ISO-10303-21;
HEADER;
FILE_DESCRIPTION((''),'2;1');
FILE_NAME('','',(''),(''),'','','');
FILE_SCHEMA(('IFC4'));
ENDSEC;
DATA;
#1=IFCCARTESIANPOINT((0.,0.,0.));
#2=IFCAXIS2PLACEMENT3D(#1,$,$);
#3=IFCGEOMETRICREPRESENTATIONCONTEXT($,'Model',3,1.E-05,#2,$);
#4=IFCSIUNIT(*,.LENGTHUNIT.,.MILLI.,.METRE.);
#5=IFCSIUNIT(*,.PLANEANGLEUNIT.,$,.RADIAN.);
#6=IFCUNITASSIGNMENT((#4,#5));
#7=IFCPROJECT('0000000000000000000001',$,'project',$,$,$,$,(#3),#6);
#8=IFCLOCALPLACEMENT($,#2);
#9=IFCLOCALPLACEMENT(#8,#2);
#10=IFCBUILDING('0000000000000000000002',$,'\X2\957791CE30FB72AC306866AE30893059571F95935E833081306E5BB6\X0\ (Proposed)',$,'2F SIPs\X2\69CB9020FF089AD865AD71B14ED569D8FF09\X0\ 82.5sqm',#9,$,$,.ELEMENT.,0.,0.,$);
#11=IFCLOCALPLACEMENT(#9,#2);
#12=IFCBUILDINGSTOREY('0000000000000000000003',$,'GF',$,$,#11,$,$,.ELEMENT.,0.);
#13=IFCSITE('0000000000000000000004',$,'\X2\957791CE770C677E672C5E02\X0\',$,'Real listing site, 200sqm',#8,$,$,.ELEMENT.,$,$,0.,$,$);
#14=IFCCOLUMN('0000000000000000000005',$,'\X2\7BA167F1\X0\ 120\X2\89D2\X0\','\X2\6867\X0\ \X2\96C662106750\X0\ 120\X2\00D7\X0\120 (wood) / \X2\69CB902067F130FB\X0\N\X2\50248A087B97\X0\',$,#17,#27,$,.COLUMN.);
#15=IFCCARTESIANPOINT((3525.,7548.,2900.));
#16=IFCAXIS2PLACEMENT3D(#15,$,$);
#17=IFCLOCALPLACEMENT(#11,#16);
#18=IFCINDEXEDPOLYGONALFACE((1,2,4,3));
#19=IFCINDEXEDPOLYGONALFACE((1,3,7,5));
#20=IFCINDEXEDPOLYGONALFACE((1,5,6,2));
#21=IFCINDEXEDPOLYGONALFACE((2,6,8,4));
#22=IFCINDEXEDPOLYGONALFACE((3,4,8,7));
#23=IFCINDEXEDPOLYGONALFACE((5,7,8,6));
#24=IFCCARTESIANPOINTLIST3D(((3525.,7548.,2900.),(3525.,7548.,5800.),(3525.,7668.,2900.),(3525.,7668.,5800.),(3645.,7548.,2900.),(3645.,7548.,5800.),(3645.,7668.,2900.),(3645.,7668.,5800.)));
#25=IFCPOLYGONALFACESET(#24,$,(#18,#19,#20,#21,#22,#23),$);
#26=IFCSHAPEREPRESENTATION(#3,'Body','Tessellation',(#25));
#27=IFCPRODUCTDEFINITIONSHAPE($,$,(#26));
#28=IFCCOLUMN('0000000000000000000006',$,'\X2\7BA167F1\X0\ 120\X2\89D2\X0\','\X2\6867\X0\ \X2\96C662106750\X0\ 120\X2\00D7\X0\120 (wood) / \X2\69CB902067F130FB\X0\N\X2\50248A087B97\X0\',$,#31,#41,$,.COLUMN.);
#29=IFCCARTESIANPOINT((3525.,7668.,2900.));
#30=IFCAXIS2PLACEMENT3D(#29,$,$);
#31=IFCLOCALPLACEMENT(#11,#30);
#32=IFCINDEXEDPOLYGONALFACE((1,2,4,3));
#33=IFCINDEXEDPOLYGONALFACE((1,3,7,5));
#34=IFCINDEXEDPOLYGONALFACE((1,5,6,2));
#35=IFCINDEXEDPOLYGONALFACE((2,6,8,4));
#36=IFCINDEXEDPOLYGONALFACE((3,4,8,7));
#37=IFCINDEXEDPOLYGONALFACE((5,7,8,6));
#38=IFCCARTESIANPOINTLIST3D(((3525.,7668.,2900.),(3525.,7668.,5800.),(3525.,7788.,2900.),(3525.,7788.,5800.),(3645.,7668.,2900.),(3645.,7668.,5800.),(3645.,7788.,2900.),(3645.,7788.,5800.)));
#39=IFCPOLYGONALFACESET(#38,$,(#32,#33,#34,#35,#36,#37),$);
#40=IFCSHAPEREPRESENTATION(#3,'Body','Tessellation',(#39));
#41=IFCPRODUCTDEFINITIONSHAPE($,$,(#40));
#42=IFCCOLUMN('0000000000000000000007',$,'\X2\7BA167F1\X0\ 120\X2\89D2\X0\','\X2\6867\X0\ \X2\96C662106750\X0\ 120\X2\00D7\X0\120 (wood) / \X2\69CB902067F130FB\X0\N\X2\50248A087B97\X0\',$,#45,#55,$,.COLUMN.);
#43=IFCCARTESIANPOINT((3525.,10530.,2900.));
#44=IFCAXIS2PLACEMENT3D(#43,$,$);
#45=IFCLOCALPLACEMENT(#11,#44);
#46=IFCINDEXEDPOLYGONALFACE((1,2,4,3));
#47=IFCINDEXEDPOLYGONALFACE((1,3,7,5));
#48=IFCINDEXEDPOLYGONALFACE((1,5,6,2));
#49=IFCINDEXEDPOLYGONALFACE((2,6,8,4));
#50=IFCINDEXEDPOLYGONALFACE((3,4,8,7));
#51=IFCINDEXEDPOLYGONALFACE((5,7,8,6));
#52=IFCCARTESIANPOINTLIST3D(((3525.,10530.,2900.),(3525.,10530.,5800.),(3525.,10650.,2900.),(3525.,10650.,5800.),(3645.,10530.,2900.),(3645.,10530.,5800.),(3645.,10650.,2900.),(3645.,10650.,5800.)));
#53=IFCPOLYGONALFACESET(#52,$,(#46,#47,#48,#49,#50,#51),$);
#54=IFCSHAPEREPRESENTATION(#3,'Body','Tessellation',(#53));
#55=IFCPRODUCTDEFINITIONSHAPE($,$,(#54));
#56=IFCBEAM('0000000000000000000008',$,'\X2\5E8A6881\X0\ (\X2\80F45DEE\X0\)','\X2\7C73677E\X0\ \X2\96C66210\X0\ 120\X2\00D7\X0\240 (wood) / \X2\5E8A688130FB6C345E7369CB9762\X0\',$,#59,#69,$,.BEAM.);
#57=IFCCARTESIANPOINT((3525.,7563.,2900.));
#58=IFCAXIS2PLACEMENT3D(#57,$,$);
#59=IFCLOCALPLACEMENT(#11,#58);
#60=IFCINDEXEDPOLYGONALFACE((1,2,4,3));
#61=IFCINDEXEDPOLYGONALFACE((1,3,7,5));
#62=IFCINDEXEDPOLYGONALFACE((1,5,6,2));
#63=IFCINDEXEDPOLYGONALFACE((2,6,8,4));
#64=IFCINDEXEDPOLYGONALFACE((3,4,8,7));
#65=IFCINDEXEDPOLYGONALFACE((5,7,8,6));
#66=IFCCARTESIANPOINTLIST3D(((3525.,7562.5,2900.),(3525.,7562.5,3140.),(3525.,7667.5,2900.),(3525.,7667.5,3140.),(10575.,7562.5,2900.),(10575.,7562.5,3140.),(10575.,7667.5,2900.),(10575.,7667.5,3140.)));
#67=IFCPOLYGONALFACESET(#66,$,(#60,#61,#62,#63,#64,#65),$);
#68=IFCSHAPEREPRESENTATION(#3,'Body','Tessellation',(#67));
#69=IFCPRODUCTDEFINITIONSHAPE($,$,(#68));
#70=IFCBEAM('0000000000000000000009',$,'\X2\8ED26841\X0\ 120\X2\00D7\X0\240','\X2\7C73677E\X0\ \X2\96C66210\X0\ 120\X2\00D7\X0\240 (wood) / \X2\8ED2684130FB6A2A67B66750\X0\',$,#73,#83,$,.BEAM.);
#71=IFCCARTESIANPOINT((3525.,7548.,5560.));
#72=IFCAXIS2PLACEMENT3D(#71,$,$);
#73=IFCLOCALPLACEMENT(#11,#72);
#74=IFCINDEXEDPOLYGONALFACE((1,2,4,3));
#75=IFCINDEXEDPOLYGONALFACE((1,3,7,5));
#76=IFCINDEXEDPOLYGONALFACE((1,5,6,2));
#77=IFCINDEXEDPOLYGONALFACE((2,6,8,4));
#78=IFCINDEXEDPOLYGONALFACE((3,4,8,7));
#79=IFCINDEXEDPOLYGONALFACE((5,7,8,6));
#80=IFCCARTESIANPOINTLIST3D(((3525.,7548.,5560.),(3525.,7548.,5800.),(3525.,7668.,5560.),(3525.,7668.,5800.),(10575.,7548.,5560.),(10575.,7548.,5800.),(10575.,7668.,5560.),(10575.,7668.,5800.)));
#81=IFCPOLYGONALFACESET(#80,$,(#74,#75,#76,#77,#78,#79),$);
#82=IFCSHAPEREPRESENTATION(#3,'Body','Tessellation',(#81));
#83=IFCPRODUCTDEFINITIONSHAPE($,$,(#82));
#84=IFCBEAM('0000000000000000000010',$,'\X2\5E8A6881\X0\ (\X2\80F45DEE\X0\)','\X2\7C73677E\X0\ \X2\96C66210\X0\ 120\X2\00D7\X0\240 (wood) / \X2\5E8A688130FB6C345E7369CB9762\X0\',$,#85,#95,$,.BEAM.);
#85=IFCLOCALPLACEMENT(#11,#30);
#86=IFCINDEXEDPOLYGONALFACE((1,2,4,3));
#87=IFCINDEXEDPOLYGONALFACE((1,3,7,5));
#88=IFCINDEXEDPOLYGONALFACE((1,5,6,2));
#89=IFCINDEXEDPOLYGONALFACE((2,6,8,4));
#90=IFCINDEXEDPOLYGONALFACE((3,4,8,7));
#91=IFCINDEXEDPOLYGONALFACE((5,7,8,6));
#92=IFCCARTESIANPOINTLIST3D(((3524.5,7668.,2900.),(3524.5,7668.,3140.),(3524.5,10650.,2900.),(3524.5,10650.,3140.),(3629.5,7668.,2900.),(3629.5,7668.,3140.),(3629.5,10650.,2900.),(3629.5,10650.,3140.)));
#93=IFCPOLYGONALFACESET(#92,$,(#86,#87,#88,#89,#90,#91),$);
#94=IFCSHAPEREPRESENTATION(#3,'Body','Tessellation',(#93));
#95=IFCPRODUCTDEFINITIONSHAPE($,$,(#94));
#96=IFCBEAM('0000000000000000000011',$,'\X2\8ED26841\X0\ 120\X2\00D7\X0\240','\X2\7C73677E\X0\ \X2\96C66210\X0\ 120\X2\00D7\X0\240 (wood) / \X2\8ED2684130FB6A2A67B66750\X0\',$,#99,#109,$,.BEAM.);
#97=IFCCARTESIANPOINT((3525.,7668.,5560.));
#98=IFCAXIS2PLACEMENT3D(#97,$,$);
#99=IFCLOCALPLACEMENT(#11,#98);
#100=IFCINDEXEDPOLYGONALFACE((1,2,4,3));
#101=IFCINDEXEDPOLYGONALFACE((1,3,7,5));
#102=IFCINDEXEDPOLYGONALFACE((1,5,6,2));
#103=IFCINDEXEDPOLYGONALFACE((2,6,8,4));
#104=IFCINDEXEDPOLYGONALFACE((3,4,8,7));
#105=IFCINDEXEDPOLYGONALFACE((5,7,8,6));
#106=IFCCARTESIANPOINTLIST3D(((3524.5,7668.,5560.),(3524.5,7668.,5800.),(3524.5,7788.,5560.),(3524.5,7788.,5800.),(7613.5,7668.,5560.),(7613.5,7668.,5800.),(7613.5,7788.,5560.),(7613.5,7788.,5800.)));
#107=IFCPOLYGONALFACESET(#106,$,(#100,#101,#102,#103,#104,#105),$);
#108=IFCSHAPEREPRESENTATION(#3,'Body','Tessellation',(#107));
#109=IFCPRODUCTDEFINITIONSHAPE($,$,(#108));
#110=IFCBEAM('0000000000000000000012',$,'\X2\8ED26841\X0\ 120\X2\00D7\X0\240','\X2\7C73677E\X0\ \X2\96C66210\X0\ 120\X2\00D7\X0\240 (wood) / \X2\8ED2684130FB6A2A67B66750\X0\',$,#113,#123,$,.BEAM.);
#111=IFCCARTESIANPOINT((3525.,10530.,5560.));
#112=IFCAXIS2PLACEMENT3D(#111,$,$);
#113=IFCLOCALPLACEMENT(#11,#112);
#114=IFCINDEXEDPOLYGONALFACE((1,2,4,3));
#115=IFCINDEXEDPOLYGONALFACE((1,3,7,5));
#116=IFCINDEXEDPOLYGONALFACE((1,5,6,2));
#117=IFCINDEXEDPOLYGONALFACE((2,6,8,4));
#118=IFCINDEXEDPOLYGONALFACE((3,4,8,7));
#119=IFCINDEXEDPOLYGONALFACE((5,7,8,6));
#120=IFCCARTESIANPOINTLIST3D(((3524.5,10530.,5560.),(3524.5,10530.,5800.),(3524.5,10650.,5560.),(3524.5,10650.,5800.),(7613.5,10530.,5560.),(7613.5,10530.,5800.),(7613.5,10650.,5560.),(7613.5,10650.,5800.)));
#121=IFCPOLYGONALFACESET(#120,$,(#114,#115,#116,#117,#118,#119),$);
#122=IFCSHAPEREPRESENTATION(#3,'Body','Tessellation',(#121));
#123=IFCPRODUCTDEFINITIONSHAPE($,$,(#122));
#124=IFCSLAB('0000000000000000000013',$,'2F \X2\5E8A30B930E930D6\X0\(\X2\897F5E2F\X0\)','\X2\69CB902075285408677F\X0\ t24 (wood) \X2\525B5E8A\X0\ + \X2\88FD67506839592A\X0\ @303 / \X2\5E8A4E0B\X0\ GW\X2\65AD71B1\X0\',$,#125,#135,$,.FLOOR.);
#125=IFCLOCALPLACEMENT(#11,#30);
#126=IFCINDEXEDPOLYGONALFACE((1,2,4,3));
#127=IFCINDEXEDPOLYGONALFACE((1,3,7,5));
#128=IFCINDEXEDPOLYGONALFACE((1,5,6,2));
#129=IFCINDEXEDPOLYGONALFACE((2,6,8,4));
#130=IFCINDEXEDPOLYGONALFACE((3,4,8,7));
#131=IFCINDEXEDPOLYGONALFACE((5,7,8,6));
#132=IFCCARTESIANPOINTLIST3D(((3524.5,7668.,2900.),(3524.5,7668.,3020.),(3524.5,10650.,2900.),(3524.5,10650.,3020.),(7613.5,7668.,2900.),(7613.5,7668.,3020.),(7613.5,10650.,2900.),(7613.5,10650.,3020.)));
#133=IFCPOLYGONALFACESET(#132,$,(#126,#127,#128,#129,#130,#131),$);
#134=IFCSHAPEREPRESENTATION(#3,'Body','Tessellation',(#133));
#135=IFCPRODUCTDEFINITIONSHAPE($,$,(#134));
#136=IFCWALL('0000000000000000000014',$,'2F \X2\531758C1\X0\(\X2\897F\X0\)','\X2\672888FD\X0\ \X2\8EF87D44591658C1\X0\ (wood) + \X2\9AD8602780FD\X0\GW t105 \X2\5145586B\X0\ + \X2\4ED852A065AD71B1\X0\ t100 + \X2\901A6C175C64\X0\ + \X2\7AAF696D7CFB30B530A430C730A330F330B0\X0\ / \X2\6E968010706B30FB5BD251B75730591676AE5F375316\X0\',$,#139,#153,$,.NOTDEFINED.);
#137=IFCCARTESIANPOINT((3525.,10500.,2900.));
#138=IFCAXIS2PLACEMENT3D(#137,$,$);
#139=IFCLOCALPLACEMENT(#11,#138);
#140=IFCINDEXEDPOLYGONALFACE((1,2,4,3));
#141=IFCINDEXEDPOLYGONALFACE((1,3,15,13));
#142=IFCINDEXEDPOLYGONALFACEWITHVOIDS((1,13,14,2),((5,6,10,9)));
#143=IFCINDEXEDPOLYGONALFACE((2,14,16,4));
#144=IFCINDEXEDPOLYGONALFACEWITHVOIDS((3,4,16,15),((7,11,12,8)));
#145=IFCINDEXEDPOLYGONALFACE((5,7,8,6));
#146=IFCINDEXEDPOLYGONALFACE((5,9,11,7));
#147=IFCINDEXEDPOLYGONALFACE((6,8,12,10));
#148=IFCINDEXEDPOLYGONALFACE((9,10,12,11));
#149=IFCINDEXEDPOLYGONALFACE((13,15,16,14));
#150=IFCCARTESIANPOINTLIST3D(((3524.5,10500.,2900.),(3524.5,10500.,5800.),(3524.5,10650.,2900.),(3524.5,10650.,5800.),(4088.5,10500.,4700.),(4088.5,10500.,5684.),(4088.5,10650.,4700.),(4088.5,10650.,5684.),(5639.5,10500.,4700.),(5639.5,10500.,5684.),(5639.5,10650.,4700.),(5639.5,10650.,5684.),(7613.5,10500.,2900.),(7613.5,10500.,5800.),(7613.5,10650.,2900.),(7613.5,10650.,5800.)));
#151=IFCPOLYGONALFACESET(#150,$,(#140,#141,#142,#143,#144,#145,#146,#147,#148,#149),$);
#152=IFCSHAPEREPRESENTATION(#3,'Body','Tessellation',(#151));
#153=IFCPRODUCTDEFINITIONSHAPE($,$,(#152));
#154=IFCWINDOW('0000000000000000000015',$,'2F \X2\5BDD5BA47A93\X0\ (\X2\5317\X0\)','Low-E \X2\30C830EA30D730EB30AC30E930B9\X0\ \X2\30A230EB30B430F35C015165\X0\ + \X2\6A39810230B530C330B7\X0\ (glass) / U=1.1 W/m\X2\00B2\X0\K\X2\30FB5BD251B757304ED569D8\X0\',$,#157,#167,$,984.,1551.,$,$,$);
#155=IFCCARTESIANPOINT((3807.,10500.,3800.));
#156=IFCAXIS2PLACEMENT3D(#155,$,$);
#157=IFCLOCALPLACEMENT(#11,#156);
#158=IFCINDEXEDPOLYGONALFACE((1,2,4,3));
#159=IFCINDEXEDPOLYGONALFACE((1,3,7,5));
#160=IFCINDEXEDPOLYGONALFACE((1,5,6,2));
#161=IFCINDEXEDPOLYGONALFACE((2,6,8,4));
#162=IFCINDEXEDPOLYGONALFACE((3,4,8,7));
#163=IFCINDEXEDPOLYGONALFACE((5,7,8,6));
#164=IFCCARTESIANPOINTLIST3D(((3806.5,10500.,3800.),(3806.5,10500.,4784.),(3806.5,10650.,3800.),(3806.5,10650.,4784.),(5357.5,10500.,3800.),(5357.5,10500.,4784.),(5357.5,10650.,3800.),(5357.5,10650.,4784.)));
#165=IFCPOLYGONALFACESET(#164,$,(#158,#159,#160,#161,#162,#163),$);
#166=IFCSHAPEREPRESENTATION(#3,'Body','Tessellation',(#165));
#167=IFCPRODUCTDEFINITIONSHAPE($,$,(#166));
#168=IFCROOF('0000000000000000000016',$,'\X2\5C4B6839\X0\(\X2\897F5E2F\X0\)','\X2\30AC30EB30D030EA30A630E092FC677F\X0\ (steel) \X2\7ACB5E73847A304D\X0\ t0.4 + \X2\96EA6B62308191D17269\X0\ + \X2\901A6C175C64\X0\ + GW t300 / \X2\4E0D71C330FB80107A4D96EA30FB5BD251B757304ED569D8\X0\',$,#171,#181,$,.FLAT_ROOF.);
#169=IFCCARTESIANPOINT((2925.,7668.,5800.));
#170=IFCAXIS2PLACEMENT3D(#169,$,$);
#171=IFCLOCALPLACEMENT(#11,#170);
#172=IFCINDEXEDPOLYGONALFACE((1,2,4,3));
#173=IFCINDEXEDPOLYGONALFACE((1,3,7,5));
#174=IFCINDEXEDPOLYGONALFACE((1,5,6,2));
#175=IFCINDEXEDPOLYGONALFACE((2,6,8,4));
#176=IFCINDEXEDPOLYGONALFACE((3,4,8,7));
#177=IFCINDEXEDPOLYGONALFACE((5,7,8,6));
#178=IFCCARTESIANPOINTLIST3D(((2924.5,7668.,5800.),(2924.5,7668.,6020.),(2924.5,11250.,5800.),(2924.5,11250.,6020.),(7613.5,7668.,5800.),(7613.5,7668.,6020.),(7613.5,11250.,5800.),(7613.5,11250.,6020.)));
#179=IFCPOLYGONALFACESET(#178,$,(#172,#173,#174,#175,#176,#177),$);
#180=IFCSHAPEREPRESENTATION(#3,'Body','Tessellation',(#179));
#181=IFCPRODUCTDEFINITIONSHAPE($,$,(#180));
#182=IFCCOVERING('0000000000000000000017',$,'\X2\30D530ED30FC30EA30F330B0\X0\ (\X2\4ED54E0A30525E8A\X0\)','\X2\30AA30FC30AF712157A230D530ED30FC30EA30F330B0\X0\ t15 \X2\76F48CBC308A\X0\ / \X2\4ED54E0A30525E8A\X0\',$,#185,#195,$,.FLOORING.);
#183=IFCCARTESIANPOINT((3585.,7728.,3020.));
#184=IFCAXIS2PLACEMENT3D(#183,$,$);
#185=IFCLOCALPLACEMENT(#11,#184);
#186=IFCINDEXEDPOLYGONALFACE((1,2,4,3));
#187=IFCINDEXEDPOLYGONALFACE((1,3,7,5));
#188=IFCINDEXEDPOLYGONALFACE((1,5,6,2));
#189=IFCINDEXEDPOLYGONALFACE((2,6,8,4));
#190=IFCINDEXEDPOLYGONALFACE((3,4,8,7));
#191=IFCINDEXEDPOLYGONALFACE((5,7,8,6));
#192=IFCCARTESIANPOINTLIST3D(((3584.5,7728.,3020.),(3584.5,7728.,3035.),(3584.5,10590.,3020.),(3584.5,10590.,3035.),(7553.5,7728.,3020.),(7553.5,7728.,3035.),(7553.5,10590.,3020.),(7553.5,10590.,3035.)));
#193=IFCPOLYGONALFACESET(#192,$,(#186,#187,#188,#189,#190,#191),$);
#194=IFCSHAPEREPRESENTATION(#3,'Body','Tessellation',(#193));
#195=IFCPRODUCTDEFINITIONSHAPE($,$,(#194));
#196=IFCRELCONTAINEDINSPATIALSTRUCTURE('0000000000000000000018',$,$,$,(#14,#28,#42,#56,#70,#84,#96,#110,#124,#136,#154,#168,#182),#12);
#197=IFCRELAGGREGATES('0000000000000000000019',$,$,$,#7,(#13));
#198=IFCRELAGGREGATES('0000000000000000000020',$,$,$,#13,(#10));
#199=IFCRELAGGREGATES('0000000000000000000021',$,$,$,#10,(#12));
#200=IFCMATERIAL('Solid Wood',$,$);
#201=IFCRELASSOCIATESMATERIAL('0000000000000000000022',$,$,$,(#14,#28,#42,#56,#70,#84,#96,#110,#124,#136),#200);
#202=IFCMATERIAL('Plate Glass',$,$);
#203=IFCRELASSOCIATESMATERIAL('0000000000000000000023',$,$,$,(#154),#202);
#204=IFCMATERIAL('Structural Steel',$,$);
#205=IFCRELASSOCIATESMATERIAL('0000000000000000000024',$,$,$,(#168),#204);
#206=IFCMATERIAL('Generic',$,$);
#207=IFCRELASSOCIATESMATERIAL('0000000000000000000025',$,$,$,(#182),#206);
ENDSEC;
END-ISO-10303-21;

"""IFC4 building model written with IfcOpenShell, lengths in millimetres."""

from ifc_helpers import new_model, si_unit, frame, frame_2d, origin, place, context, project, spatial, rectangle, extrude, material, element, fill, save


model = new_model("IFC4")

# Units and contexts
model_context = context("Model", 3, precision=1e-05, world=origin())
ifc_project = project(units=[si_unit("LENGTHUNIT", "METRE", prefix="MILLI"), si_unit("PLANEANGLEUNIT", "RADIAN")], contexts=[model_context])

# Site, building, storey
site_placement = place(None, origin())
site = spatial("IfcSite", under=ifc_project, at=site_placement, Name="長野県松本市", ObjectType="Real listing site, 200sqm", CompositionType="ELEMENT", RefElevation=0.0)
building_placement = place(site_placement, origin())
building = spatial("IfcBuilding", under=site, at=building_placement, Name="長野・犬と暮らす土間広めの家 (Proposed)", ObjectType="2F SIPs構造（高断熱仕様） 82.5sqm", CompositionType="ELEMENT", ElevationOfRefHeight=0.0, ElevationOfTerrain=0.0)
storey_placement = place(building_placement, origin())
storey = spatial("IfcBuildingStorey", under=building, at=storey_placement, Name="GF", CompositionType="ELEMENT", Elevation=0.0)

# Columns
ifc_material_1 = material(Name="Solid Wood")
column_1_placement = place(storey_placement, frame((3525.0, 7548.0, 2900.0)))
element("IfcColumn", 1, at=column_1_placement, inside=storey, material=ifc_material_1, Name="管柱 120角", Description="桧 集成材 120×120 (wood) / 構造柱・N値計算", PredefinedType="COLUMN", context=model_context, shape_type="SweptSolid", body=[
    extrude(rectangle(XDim=120.0, YDim=120.0, at=frame_2d((60.0, 60.0))), frame((3525.0, 7548.0, 2900.0)), (0.0, 0.0, 1.0), 2900.0),
])
column_2_placement = place(storey_placement, frame((3525.0, 7668.0, 2900.0)))
element("IfcColumn", 2, at=column_2_placement, inside=storey, material=ifc_material_1, Name="管柱 120角", Description="桧 集成材 120×120 (wood) / 構造柱・N値計算", PredefinedType="COLUMN", context=model_context, shape_type="SweptSolid", body=[
    extrude(rectangle(XDim=120.0, YDim=120.0, at=frame_2d((60.0, 60.0))), frame((3525.0, 7668.0, 2900.0)), (0.0, 0.0, 1.0), 2900.0),
])
column_3_placement = place(storey_placement, frame((3525.0, 10530.0, 2900.0)))
element("IfcColumn", 3, at=column_3_placement, inside=storey, material=ifc_material_1, Name="管柱 120角", Description="桧 集成材 120×120 (wood) / 構造柱・N値計算", PredefinedType="COLUMN", context=model_context, shape_type="SweptSolid", body=[
    extrude(rectangle(XDim=120.0, YDim=120.0, at=frame_2d((60.0, 60.0))), frame((3525.0, 10530.0, 2900.0)), (0.0, 0.0, 1.0), 2900.0),
])

# Beams
beam_1_placement = place(storey_placement, frame((3525.0, 7563.0, 2900.0)))
element("IfcBeam", 4, at=beam_1_placement, inside=storey, material=ifc_material_1, Name="床梁 (胴差)", Description="米松 集成 120×240 (wood) / 床梁・水平構面", PredefinedType="BEAM", context=model_context, shape_type="SweptSolid", body=[
    extrude(rectangle(XDim=7050.0, YDim=105.0, at=frame_2d((3525.0, 52.0))), frame((3525.0, 7563.0, 2900.0)), (0.0, 0.0, 1.0), 240.0),
])
beam_2_placement = place(storey_placement, frame((3525.0, 7548.0, 5560.0)))
element("IfcBeam", 5, at=beam_2_placement, inside=storey, material=ifc_material_1, Name="軒桁 120×240", Description="米松 集成 120×240 (wood) / 軒桁・横架材", PredefinedType="BEAM", context=model_context, shape_type="SweptSolid", body=[
    extrude(rectangle(XDim=7050.0, YDim=120.0, at=frame_2d((3525.0, 60.0))), frame((3525.0, 7548.0, 5560.0)), (0.0, 0.0, 1.0), 240.0),
])
beam_3_placement = place(storey_placement, frame((3525.0, 7668.0, 2900.0)))
element("IfcBeam", 6, at=beam_3_placement, inside=storey, material=ifc_material_1, Name="床梁 (胴差)", Description="米松 集成 120×240 (wood) / 床梁・水平構面", PredefinedType="BEAM", context=model_context, shape_type="SweptSolid", body=[
    extrude(rectangle(XDim=105.0, YDim=2982.0, at=frame_2d((52.0, 1491.0))), frame((3525.0, 7668.0, 2900.0)), (0.0, 0.0, 1.0), 240.0),
])
beam_4_placement = place(storey_placement, frame((3525.0, 7668.0, 5560.0)))
element("IfcBeam", 7, at=beam_4_placement, inside=storey, material=ifc_material_1, Name="軒桁 120×240", Description="米松 集成 120×240 (wood) / 軒桁・横架材", PredefinedType="BEAM", context=model_context, shape_type="SweptSolid", body=[
    extrude(rectangle(XDim=4089.0, YDim=120.0, at=frame_2d((2044.0, 60.0))), frame((3525.0, 7668.0, 5560.0)), (0.0, 0.0, 1.0), 240.0),
])
beam_5_placement = place(storey_placement, frame((3525.0, 10530.0, 5560.0)))
element("IfcBeam", 8, at=beam_5_placement, inside=storey, material=ifc_material_1, Name="軒桁 120×240", Description="米松 集成 120×240 (wood) / 軒桁・横架材", PredefinedType="BEAM", context=model_context, shape_type="SweptSolid", body=[
    extrude(rectangle(XDim=4089.0, YDim=120.0, at=frame_2d((2044.0, 60.0))), frame((3525.0, 10530.0, 5560.0)), (0.0, 0.0, 1.0), 240.0),
])

# Slab
slab_placement = place(storey_placement, frame((3525.0, 7668.0, 2900.0)))
element("IfcSlab", 9, at=slab_placement, inside=storey, material=ifc_material_1, Name="2F 床スラブ(西帯)", Description="構造用合板 t24 (wood) 剛床 + 製材根太 @303 / 床下 GW断熱", PredefinedType="FLOOR", context=model_context, shape_type="SweptSolid", body=[
    extrude(rectangle(XDim=4089.0, YDim=2982.0, at=frame_2d((2044.0, 1491.0))), frame((3525.0, 7668.0, 2900.0)), (0.0, 0.0, 1.0), 120.0),
])

# Wall, opening, window
wall_1_placement = place(storey_placement, frame((3525.0, 10500.0, 2900.0)))
wall_1 = element("IfcWall", 10, at=wall_1_placement, inside=storey, material=ifc_material_1, Name="2F 北壁(西)", Description="木製 軸組外壁 (wood) + 高性能GW t105 充填 + 付加断熱 t100 + 通気層 + 窯業系サイディング / 準耐火・寒冷地外皮強化", PredefinedType="NOTDEFINED", context=model_context, shape_type="SweptSolid", body=[
    extrude(rectangle(XDim=4089.0, YDim=150.0, at=frame_2d((2044.0, 75.0))), frame((3525.0, 10500.0, 2900.0)), (0.0, 0.0, 1.0), 2900.0),
])
opening_placement = place(storey_placement, frame((3807.0, 10500.0, 3800.0)))
opening = element("IfcOpeningElement", 11, at=opening_placement, cuts=wall_1, PredefinedType="NOTDEFINED", context=model_context, shape_type="SweptSolid", body=[
    extrude(rectangle(XDim=1551.0, YDim=150.0, at=frame_2d((775.0, 75.0))), frame((3807.0, 10500.0, 3800.0)), (0.0, 0.0, 1.0), 984.0),
])
ifc_material_2 = material(Name="Plate Glass")
window_placement = place(storey_placement, frame((3807.0, 10500.0, 3800.0)))
window = element("IfcWindow", 12, at=window_placement, inside=storey, material=ifc_material_2, Name="2F 寝室窓 (北)", Description="Low-E トリプルガラス アルゴン封入 + 樹脂サッシ (glass) / U=1.1 W/m²K・寒冷地仕様", OverallHeight=984.0, OverallWidth=1551.0, context=model_context, shape_type="SweptSolid", body=[
    extrude(rectangle(XDim=1551.0, YDim=150.0, at=frame_2d((775.0, 75.0))), frame((3807.0, 10500.0, 3800.0)), (0.0, 0.0, 1.0), 984.0),
])
fill(opening, window)

# Roof
ifc_material_3 = material(Name="Structural Steel")
for number, where, name in (
    (13, (2925.0, 7668.0, 5800.0), "屋根(西帯)"),
):
    element("IfcRoof", number, at=place(storey_placement, frame(where)), inside=storey, material=ifc_material_3, Name=name, Description="ガルバリウム鋼板 (steel) 立平葺き t0.4 + 雪止め金物 + 通気層 + GW t300 / 不燃・耐積雪・寒冷地仕様", PredefinedType="FLAT_ROOF", context=model_context, shape_type="SweptSolid", body=[
        extrude(rectangle(XDim=4689.0, YDim=3582.0, at=frame_2d((2344.0, 1791.0))), frame((2925.0, 7668.0, 5800.0)), (0.0, 0.0, 1.0), 220.0),
    ])

# Covering
ifc_material_4 = material(Name="Generic")
covering_placement = place(storey_placement, frame((3585.0, 7728.0, 3020.0)))
element("IfcCovering", 14, at=covering_placement, inside=storey, material=ifc_material_4, Name="フローリング (仕上げ床)", Description="オーク無垢フローリング t15 直貼り / 仕上げ床", PredefinedType="FLOORING", context=model_context, shape_type="SweptSolid", body=[
    extrude(rectangle(XDim=3969.0, YDim=2862.0, at=frame_2d((1984.0, 1431.0))), frame((3585.0, 7728.0, 3020.0)), (0.0, 0.0, 1.0), 15.0),
])

save(model, "model.ifc")
